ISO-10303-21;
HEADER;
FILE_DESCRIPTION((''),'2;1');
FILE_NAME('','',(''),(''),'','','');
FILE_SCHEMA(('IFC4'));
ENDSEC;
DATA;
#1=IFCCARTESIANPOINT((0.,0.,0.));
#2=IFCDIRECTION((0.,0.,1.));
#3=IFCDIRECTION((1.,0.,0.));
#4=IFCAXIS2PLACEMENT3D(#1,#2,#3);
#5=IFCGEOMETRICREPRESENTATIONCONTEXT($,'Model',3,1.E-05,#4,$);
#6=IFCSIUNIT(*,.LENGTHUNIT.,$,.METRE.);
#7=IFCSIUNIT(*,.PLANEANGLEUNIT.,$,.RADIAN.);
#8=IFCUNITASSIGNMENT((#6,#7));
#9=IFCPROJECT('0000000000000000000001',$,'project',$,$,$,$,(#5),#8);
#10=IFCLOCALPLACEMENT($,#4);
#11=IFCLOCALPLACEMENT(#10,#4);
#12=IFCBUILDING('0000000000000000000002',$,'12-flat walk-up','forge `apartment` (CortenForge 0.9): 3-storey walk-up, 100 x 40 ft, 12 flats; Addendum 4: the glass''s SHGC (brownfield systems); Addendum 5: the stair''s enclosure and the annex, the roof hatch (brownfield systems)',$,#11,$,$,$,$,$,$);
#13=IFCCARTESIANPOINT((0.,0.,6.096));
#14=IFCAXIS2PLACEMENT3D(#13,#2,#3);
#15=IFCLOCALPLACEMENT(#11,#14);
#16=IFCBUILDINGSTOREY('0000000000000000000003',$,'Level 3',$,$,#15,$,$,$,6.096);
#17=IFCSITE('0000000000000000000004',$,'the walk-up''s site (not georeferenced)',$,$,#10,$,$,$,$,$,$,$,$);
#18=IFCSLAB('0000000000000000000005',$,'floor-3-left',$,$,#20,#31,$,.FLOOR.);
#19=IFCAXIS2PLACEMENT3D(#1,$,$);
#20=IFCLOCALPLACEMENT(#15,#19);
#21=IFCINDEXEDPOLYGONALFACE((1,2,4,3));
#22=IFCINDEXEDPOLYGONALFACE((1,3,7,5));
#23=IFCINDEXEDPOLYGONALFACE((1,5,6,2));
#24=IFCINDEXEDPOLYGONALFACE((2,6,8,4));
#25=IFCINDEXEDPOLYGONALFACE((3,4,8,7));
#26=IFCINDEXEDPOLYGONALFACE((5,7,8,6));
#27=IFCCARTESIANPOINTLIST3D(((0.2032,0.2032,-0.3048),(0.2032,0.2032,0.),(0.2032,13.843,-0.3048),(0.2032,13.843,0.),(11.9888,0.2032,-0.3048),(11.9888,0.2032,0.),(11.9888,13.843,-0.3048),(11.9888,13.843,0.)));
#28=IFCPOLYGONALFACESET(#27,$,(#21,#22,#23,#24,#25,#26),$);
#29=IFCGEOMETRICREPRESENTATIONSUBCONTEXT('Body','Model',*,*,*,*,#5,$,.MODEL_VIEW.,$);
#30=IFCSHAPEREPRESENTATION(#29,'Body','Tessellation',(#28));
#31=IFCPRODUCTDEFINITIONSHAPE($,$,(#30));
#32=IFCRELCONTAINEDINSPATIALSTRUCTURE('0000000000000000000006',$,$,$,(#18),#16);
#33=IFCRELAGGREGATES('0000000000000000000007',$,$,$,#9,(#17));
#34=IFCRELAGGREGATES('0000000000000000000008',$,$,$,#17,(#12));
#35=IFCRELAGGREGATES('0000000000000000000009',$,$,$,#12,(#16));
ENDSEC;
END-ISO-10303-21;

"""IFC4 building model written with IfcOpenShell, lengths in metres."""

from ifc_helpers import new_model, si_unit, frame, frame_2d, origin, origin_with_axes, place, context, subcontext, project, spatial, rectangle, extrude, element, save


model = new_model("IFC4")

# Units and contexts
model_context = context("Model", 3, precision=1e-05, world=origin_with_axes())
body_context = subcontext(model_context, "Body", "Model", "MODEL_VIEW")
ifc_project = project(units=[si_unit("LENGTHUNIT", "METRE"), si_unit("PLANEANGLEUNIT", "RADIAN")], contexts=[model_context])

# Site, building, storey
site_placement = place(None, origin_with_axes())
site = spatial("IfcSite", under=ifc_project, at=site_placement, Name="the walk-up's site (not georeferenced)")
building_placement = place(site_placement, origin_with_axes())
building = spatial("IfcBuilding", under=site, at=building_placement, Name="12-flat walk-up", Description="forge `apartment` (CortenForge 0.9): 3-storey walk-up, 100 x 40 ft, 12 flats; Addendum 4: the glass's SHGC (brownfield systems); Addendum 5: the stair's enclosure and the annex, the roof hatch (brownfield systems)")
storey_placement = place(building_placement, frame((0.0, 0.0, 6.096), z_axis=(0.0, 0.0, 1.0), x_axis=(1.0, 0.0, 0.0)))
storey = spatial("IfcBuildingStorey", under=building, at=storey_placement, Name="Level 3", Elevation=6.096)

# Slab
slab_placement = place(storey_placement, frame((0.2032, 0.2032, -0.3048), z_axis=(0.0, 0.0, 1.0), x_axis=(1.0, 0.0, 0.0)))
element("IfcSlab", 1, at=slab_placement, inside=storey, Name="floor-3-left", PredefinedType="FLOOR", context=body_context, shape_type="SweptSolid", body=[
    extrude(rectangle(XDim=11.7856, YDim=13.6398, at=frame_2d((5.8928, 6.8199))), origin(), (0.0, 0.0, 1.0), 0.3048),
])

save(model, "model.ifc")
